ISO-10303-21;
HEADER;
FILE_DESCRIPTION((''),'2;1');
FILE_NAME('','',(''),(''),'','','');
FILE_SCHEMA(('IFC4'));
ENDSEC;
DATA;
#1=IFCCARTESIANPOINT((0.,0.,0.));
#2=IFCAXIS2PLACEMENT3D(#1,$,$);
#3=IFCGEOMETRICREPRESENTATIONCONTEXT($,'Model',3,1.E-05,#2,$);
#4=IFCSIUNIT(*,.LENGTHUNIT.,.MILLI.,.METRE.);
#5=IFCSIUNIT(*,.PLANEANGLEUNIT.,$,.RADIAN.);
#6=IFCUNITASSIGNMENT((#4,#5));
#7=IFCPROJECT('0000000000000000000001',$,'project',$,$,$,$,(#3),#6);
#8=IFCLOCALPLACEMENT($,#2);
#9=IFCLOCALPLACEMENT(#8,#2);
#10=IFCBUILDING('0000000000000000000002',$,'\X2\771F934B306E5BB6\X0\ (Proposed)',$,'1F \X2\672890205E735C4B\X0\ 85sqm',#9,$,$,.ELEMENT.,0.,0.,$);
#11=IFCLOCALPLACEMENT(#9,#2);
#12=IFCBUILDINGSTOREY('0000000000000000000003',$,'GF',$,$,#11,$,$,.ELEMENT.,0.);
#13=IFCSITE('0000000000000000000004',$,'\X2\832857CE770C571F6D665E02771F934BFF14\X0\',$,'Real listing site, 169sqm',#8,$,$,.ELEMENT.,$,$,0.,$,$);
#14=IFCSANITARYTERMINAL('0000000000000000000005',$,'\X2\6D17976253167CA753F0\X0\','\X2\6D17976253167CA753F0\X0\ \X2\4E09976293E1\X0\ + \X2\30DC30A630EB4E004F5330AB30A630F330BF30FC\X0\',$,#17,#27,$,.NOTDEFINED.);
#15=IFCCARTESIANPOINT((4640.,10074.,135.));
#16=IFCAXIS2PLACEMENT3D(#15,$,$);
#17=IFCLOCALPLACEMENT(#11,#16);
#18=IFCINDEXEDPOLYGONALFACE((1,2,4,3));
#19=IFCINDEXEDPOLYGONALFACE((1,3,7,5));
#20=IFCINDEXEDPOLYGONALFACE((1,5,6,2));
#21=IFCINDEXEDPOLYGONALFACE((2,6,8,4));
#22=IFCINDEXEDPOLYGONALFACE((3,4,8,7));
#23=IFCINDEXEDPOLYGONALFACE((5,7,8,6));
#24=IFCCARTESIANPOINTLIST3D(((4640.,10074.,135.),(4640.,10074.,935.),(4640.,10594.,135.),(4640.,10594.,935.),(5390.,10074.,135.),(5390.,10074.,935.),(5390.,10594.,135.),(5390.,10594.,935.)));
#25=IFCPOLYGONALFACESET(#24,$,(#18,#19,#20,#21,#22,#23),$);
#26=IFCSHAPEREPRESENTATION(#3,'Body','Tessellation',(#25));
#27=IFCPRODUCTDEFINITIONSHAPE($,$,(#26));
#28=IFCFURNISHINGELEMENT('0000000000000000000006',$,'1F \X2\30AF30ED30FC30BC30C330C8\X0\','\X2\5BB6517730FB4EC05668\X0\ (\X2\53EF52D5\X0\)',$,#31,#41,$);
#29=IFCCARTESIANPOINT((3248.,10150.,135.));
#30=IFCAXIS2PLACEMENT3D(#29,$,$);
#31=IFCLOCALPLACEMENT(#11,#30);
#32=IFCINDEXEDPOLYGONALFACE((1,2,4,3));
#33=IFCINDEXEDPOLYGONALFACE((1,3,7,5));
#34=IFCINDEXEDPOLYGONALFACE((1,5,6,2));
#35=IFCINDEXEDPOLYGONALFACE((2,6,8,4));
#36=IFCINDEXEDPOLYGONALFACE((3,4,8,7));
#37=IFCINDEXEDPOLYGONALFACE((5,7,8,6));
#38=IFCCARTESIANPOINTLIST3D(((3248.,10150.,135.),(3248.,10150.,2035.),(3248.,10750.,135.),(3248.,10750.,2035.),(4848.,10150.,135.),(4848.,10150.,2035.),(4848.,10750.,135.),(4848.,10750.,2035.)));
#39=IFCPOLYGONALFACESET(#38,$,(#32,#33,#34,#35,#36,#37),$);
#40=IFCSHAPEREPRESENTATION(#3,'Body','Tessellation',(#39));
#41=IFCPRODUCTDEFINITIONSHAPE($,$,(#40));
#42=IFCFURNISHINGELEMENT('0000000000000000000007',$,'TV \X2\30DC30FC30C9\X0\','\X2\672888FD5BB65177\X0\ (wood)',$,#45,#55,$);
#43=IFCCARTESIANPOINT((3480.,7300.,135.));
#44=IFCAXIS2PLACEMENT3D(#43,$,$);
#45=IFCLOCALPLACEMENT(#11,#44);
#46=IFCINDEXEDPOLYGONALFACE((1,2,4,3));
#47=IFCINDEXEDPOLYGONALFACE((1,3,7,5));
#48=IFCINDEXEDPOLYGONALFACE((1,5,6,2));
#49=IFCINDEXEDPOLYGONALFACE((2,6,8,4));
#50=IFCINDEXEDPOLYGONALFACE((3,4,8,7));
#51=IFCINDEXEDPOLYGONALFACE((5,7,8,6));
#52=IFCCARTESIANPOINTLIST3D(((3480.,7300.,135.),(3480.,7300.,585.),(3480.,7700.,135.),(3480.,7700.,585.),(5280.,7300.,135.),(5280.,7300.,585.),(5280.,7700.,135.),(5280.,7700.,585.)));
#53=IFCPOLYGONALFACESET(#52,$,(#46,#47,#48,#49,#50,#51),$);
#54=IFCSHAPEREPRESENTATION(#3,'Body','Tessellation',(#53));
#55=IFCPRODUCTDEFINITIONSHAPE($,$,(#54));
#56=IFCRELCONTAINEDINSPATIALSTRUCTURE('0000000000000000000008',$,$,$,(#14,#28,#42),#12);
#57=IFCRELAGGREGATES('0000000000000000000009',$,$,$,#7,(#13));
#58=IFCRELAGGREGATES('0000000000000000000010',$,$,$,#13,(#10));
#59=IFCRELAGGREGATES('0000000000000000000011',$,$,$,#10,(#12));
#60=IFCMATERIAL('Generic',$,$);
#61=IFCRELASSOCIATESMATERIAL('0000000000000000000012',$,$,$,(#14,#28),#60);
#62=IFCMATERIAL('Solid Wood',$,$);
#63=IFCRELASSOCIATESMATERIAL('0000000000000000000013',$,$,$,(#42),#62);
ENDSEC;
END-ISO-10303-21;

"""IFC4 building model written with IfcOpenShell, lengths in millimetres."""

from ifc_helpers import new_model, si_unit, frame, frame_2d, origin, place, context, project, spatial, rectangle, extrude, material, element, save


model = new_model("IFC4")

# Units and contexts
model_context = context("Model", 3, precision=1e-05, world=origin())
ifc_project = project(units=[si_unit("LENGTHUNIT", "METRE", prefix="MILLI"), si_unit("PLANEANGLEUNIT", "RADIAN")], contexts=[model_context])

# Site, building, storey
site_placement = place(None, origin())
site = spatial("IfcSite", under=ifc_project, at=site_placement, Name="茨城県土浦市真鍋４", ObjectType="Real listing site, 169sqm", CompositionType="ELEMENT", RefElevation=0.0)
building_placement = place(site_placement, origin())
building = spatial("IfcBuilding", under=site, at=building_placement, Name="真鍋の家 (Proposed)", ObjectType="1F 木造平屋 85sqm", CompositionType="ELEMENT", ElevationOfRefHeight=0.0, ElevationOfTerrain=0.0)
storey_placement = place(building_placement, origin())
storey = spatial("IfcBuildingStorey", under=building, at=storey_placement, Name="GF", CompositionType="ELEMENT", Elevation=0.0)

# Shared definitions
ifc_material_1 = material(Name="Solid Wood")

# Shared definitions
ifc_material_2 = material(Name="Generic")

# Sanitary terminal
sanitary_terminal_1_placement = place(storey_placement, frame((4640.0, 10074.0, 135.0)))
element("IfcSanitaryTerminal", 1, at=sanitary_terminal_1_placement, inside=storey, material=ifc_material_2, Name="洗面化粧台", Description="洗面化粧台 三面鏡 + ボウル一体カウンター", PredefinedType="NOTDEFINED", context=model_context, shape_type="SweptSolid", body=[
    extrude(rectangle(XDim=750.0, YDim=520.0, at=frame_2d((375.0, 260.0))), frame((4640.0, 10074.0, 135.0)), (0.0, 0.0, 1.0), 800.0),
])

# Furnishing elements
furnishing_1_placement = place(storey_placement, frame((3248.0, 10150.0, 135.0)))
element("IfcFurnishingElement", 2, at=furnishing_1_placement, inside=storey, material=ifc_material_2, Name="1F クローゼット", Description="家具・什器 (可動)", context=model_context, shape_type="SweptSolid", body=[
    extrude(rectangle(XDim=1600.0, YDim=600.0, at=frame_2d((800.0, 300.0))), frame((3248.0, 10150.0, 135.0)), (0.0, 0.0, 1.0), 1900.0),
])
furnishing_2_placement = place(storey_placement, frame((3480.0, 7300.0, 135.0)))
element("IfcFurnishingElement", 3, at=furnishing_2_placement, inside=storey, material=ifc_material_1, Name="TV ボード", Description="木製家具 (wood)", context=model_context, shape_type="SweptSolid", body=[
    extrude(rectangle(XDim=1800.0, YDim=400.0, at=frame_2d((900.0, 200.0))), frame((3480.0, 7300.0, 135.0)), (0.0, 0.0, 1.0), 450.0),
])

save(model, "model.ifc")
